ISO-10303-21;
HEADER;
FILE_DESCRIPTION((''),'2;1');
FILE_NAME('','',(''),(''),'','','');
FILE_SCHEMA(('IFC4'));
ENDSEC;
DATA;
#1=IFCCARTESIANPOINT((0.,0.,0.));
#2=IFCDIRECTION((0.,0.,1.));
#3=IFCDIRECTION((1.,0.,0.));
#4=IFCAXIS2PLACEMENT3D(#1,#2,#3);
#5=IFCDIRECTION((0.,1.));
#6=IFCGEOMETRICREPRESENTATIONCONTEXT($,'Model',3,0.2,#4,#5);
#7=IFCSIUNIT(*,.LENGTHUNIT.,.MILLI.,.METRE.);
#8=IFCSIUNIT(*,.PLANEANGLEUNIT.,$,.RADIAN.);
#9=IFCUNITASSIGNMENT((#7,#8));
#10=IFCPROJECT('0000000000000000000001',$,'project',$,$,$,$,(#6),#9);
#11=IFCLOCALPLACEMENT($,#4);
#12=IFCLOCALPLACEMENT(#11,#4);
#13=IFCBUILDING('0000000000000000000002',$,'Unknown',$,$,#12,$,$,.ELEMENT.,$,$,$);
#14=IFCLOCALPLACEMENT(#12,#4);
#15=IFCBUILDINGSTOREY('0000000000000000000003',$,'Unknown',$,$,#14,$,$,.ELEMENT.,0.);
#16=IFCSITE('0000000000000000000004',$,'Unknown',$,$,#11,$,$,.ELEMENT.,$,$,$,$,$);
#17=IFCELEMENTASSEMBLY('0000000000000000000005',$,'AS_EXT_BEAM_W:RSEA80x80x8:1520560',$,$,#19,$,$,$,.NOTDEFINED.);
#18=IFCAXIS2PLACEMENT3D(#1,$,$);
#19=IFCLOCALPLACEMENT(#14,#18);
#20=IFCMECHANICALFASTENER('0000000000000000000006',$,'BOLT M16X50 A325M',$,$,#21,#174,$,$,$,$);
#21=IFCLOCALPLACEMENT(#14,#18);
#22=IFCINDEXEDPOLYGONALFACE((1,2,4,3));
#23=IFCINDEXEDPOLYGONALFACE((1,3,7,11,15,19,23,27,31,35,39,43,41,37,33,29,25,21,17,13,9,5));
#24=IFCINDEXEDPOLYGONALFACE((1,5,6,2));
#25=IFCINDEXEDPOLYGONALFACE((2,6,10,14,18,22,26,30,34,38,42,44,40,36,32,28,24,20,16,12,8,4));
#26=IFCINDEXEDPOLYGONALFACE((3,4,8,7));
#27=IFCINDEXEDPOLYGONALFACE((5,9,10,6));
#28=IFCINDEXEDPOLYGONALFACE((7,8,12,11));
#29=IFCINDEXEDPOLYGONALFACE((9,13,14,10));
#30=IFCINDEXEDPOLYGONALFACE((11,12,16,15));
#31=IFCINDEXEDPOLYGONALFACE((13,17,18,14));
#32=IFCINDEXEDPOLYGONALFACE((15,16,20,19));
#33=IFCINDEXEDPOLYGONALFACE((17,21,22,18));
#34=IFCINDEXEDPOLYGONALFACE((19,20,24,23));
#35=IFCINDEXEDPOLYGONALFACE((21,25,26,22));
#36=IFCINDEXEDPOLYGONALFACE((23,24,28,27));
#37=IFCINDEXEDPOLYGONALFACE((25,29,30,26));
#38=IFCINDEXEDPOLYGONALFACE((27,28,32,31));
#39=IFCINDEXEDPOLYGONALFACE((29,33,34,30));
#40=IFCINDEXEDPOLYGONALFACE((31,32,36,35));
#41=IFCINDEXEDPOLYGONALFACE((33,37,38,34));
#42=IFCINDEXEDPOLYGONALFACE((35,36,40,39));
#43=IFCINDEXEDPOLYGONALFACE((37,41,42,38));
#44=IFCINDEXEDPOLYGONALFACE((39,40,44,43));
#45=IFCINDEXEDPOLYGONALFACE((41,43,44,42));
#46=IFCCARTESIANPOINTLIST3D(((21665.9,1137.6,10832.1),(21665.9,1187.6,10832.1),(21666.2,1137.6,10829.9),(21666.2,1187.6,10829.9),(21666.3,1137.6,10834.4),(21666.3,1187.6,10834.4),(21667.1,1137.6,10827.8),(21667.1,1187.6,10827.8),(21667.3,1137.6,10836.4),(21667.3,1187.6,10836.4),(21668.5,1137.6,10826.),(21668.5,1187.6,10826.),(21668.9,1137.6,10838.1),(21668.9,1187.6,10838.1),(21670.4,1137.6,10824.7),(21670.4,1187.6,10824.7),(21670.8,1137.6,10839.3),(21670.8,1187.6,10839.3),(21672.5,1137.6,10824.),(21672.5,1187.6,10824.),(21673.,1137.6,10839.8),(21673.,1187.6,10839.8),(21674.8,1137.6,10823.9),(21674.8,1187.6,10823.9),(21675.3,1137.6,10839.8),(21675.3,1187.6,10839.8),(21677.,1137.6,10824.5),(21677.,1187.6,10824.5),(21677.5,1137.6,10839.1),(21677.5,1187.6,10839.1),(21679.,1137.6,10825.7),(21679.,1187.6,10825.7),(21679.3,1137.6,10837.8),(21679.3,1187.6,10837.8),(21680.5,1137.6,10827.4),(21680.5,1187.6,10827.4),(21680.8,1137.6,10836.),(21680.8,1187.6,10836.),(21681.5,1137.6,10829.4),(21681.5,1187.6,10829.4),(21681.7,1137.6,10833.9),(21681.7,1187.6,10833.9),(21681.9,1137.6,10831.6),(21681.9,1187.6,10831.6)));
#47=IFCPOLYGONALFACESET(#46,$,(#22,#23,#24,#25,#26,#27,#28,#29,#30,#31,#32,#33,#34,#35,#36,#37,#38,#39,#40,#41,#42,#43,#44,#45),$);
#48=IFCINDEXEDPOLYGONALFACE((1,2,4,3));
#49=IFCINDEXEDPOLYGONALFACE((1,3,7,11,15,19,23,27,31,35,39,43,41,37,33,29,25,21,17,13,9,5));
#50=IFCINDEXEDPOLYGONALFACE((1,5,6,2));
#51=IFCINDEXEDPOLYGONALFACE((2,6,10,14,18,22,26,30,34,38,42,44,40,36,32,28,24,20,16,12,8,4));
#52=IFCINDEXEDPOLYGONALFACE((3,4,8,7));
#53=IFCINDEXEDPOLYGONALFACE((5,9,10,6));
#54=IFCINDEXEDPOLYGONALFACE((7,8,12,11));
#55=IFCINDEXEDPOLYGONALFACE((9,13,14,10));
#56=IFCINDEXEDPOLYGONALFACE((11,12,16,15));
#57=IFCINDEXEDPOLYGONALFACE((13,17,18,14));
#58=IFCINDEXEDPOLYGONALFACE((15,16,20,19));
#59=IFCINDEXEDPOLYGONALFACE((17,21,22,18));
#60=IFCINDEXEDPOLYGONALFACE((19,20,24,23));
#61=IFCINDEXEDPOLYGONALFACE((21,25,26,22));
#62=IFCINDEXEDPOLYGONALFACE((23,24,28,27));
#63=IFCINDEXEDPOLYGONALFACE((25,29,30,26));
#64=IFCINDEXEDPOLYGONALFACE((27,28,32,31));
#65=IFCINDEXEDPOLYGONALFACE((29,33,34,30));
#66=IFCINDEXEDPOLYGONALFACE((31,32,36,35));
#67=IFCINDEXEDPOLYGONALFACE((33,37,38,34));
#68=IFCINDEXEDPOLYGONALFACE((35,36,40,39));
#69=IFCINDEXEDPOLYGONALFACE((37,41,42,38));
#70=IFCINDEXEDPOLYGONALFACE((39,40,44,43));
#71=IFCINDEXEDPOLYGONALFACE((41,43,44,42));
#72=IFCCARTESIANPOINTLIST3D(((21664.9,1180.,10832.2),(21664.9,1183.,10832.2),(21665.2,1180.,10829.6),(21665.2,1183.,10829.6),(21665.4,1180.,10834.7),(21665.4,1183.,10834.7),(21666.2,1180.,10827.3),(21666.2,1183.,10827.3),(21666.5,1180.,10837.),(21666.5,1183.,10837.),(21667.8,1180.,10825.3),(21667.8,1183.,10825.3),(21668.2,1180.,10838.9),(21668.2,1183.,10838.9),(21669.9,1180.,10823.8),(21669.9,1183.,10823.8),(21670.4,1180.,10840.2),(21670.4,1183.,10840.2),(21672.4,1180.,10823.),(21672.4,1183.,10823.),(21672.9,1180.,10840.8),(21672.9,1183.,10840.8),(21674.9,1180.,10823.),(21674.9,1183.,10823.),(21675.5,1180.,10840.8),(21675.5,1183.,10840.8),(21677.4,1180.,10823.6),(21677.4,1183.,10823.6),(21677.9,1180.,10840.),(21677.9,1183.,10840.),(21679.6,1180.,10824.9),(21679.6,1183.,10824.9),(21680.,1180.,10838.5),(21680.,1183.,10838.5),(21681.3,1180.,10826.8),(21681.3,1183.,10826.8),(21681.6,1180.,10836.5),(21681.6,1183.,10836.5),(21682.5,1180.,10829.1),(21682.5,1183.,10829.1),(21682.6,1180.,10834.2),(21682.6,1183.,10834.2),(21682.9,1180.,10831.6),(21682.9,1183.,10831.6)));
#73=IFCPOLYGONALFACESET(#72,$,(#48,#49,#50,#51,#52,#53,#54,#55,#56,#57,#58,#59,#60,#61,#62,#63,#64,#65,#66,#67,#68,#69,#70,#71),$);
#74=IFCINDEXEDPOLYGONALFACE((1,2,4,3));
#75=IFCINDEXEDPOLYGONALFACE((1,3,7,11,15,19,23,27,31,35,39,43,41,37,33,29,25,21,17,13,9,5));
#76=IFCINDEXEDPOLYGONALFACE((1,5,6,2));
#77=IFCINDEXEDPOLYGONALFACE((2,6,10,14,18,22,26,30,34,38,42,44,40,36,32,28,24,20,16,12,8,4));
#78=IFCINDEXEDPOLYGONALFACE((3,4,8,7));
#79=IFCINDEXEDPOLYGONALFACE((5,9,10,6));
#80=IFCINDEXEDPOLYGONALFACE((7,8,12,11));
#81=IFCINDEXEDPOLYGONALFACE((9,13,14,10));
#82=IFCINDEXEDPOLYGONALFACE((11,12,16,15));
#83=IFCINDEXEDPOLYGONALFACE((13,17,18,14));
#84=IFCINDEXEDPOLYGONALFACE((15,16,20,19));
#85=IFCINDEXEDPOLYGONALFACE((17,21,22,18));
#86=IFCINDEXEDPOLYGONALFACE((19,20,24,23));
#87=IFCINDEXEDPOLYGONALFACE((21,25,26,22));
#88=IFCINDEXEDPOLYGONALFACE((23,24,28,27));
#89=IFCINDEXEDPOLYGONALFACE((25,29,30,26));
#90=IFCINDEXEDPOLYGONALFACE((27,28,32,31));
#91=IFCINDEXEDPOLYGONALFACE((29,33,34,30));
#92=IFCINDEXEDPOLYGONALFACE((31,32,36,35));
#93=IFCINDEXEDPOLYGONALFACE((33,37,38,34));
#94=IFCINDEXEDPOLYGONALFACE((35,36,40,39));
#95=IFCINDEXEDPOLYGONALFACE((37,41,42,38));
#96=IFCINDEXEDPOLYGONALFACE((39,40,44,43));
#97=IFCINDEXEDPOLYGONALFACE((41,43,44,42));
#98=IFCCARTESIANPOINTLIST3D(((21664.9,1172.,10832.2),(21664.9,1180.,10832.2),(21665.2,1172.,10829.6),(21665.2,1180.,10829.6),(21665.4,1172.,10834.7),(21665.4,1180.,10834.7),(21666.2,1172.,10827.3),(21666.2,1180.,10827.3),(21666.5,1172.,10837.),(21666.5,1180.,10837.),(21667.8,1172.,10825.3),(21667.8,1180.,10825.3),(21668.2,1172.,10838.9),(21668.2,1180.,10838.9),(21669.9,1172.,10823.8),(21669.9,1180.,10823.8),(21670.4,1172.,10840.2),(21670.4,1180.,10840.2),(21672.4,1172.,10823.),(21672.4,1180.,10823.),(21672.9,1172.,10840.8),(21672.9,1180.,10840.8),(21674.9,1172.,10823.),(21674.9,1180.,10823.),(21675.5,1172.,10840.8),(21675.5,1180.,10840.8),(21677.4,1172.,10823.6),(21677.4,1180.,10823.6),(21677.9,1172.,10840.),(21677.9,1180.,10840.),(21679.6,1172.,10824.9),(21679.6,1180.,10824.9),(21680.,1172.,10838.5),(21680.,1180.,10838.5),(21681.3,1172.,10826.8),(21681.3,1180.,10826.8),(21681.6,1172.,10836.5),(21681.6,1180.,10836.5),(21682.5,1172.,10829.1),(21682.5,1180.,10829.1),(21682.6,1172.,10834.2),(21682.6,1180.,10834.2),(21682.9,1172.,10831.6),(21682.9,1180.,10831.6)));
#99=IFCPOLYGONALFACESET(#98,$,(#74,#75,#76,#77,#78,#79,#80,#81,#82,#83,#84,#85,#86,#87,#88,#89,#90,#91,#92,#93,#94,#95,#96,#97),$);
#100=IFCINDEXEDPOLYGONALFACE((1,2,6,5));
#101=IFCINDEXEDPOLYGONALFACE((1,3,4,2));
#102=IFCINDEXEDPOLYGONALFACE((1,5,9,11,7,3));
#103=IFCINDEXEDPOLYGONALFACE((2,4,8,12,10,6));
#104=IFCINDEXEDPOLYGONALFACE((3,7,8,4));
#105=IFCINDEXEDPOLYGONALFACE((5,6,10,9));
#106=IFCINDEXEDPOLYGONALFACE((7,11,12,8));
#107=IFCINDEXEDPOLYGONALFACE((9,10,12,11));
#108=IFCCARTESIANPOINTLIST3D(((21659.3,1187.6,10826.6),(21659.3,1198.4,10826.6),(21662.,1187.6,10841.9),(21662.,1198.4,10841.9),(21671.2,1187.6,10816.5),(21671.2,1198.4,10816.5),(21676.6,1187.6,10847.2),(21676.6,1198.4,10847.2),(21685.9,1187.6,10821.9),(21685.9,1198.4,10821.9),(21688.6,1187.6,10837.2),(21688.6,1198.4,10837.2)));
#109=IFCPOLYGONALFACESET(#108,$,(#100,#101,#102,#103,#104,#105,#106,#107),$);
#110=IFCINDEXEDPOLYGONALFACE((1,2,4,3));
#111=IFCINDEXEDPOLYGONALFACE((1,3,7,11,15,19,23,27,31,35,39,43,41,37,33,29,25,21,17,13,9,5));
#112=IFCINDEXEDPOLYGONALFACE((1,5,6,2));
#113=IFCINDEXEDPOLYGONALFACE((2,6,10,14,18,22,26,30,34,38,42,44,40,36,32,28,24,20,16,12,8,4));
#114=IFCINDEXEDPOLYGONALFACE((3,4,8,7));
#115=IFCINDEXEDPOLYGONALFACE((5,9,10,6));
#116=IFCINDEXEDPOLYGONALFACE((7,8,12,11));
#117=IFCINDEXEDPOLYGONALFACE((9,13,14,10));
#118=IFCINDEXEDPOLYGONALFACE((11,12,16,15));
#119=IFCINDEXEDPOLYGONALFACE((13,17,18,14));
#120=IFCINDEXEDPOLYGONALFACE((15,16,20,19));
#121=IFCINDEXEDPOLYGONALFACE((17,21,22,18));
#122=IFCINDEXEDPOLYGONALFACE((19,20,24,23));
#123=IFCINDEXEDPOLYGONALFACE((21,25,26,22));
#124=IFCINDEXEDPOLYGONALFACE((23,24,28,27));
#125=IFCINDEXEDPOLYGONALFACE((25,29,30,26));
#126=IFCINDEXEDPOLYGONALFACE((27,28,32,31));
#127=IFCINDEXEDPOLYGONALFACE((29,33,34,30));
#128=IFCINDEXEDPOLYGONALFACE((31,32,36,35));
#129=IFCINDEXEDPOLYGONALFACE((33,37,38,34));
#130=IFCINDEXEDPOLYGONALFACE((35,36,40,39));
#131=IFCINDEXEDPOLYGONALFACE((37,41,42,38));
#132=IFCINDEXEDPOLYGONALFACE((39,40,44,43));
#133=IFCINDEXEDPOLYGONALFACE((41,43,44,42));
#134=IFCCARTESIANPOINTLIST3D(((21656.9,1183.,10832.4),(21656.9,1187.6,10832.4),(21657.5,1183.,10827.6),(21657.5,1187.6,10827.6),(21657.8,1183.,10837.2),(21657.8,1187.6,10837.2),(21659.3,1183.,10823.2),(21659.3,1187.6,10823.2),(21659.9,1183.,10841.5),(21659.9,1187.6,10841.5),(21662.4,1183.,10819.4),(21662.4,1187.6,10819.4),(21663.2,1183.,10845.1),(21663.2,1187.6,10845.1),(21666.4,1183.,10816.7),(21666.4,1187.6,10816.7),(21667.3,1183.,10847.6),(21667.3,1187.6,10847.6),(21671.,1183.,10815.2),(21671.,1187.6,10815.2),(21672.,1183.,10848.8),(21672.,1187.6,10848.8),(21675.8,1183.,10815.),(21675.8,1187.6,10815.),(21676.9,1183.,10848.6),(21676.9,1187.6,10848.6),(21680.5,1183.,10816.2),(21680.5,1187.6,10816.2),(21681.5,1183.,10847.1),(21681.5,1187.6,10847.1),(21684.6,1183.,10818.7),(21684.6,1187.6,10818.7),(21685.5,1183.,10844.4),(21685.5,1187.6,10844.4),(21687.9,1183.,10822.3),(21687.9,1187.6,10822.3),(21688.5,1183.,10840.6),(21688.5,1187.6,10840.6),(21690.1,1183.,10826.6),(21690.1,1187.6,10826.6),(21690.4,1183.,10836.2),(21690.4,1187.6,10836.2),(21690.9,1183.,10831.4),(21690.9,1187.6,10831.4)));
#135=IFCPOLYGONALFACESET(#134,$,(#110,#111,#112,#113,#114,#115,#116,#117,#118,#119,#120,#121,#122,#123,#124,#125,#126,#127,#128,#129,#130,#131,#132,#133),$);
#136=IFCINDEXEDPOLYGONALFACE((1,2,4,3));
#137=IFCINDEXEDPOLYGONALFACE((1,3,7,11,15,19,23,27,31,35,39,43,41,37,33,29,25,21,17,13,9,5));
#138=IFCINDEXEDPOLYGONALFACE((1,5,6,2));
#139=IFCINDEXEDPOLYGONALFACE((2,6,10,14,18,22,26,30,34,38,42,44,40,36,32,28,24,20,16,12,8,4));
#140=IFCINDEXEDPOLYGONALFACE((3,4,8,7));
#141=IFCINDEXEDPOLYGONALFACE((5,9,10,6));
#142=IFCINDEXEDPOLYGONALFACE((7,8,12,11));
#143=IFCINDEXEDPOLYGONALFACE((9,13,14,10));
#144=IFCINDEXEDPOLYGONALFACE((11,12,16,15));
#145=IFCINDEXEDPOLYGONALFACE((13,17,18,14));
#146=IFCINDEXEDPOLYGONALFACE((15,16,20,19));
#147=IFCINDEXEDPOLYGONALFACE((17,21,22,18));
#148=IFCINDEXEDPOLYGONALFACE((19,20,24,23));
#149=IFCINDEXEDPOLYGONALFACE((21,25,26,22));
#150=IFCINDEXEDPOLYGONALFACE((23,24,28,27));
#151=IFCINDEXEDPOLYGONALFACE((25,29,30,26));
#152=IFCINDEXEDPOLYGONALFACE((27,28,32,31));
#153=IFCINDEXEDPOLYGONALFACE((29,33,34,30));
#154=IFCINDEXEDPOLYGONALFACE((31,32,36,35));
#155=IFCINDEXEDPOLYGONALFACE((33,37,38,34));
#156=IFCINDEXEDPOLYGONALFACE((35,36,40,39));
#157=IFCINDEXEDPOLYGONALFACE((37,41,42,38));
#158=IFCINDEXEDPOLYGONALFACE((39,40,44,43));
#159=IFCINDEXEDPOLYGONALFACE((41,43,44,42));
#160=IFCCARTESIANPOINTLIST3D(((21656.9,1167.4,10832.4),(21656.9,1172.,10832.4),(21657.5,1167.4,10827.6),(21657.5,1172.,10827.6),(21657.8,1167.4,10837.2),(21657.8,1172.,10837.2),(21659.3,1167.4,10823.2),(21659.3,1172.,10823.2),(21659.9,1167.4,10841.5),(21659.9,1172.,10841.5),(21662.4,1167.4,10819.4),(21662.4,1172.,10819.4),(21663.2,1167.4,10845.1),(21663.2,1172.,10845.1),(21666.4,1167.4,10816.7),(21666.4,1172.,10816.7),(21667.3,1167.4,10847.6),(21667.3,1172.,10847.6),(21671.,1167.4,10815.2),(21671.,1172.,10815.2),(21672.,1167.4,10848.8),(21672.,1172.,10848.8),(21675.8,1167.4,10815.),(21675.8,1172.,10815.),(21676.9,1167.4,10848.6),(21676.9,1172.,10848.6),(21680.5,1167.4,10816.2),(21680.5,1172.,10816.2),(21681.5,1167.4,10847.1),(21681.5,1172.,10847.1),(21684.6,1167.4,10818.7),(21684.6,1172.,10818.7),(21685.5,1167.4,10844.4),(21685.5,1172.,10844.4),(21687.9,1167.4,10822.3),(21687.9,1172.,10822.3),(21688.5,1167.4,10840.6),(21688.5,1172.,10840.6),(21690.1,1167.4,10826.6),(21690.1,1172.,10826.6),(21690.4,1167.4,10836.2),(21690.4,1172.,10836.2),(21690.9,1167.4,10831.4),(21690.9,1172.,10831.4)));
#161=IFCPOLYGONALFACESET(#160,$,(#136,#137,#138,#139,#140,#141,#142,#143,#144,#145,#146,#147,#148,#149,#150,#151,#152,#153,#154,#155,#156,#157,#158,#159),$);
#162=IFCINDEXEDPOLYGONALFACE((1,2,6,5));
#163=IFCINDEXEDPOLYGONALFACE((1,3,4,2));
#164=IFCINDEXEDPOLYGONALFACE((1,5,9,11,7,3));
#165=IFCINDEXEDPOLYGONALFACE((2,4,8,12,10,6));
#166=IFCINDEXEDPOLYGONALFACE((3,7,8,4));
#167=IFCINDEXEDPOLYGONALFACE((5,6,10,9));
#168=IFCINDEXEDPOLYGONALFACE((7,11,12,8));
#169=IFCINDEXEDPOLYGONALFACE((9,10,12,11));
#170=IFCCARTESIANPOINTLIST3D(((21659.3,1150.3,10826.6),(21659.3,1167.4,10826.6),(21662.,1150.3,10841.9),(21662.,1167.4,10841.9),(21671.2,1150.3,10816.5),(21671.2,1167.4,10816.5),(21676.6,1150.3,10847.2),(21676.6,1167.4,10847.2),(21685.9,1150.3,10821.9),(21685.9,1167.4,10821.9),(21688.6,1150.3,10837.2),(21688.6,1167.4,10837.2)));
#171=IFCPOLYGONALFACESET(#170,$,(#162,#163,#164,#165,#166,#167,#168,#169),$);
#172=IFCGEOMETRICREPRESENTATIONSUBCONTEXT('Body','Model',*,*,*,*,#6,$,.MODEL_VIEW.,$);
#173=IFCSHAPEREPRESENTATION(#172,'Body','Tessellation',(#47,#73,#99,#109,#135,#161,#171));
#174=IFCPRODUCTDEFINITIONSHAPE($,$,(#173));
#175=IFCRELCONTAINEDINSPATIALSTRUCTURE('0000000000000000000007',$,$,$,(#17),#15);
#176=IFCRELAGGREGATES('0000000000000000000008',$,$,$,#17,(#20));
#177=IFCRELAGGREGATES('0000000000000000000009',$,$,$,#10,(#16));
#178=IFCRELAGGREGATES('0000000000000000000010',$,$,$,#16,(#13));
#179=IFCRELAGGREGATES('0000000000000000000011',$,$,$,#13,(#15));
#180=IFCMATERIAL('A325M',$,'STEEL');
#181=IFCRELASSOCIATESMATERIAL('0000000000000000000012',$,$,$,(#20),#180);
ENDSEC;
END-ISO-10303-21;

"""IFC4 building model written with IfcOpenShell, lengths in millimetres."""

from ifc_helpers import new_model, si_unit, direction, frame, origin_with_axes, place, context, subcontext, project, spatial, line, arc, indexed_curve, outline, extrude, source, transform, mapped, material, element, aggregate, save


model = new_model("IFC4")

# Units and contexts
model_context = context("Model", 3, precision=0.2, world=origin_with_axes(), true_north=direction((0.0, 1.0)))
body_context = subcontext(model_context, "Body", "Model", "MODEL_VIEW")
ifc_project = project(units=[si_unit("LENGTHUNIT", "METRE", prefix="MILLI"), si_unit("PLANEANGLEUNIT", "RADIAN")], contexts=[model_context])

# Site, building, storey
site_placement = place(None, origin_with_axes())
site = spatial("IfcSite", under=ifc_project, at=site_placement, Name="Unknown", CompositionType="ELEMENT")
building_placement = place(site_placement, origin_with_axes())
building = spatial("IfcBuilding", under=site, at=building_placement, Name="Unknown", CompositionType="ELEMENT")
storey_placement = place(building_placement, origin_with_axes())
storey = spatial("IfcBuildingStorey", under=building, at=storey_placement, Name="Unknown", CompositionType="ELEMENT", Elevation=0.0)

# Shared definitions
ifc_material_1 = material(Name="A325M", Category="STEEL")
shared_shape = source(origin_with_axes(), body_context, "Body", "SweptSolid", [
    extrude(outline(indexed_curve([(8.0, 0.0), (0.0, 8.0), (-8.0, 0.0), (0.0, -8.0)], segments=[arc(1, 2, 3), arc(3, 4, 1)])), frame((0.0, 0.0, 15.6), z_axis=(0.0, 0.0, -1.0), x_axis=(0.0, 1.0, 0.0)), (0.0, 0.0, 1.0), 50.0),
    extrude(outline(indexed_curve([(9.0, 0.0), (0.0, 9.0), (-9.0, 0.0), (0.0, -9.0)], segments=[arc(1, 2, 3), arc(3, 4, 1)])), frame((0.0, 0.0, 11.0), z_axis=(0.0, 0.0, -1.0), x_axis=(0.0, 1.0, 0.0)), (0.0, 0.0, 1.0), 3.0),
    extrude(outline(indexed_curve([(9.0, 0.0), (0.0, 9.0), (-9.0, 0.0), (0.0, -9.0)], segments=[arc(1, 2, 3), arc(3, 4, 1)])), frame((0.0, 0.0, 8.0), z_axis=(0.0, 0.0, -1.0), x_axis=(0.0, 1.0, 0.0)), (0.0, 0.0, 1.0), 8.0),
    extrude(outline(indexed_curve([(15.6, 0.0), (7.8, 13.5), (-7.8, 13.5), (-15.6, 0.0), (-7.8, -13.5), (7.8, -13.5)], segments=[line(1, 2, 3, 4, 5, 6, 1)])), frame((0.0, 0.0, 26.4), z_axis=(0.0, 0.0, -1.0), x_axis=(0.0, 1.0, 0.0)), (0.0, 0.0, 1.0), 10.8),
    extrude(outline(indexed_curve([(17.0, 0.0), (0.0, 17.0), (-17.0, 0.0), (0.0, -17.0)], segments=[arc(1, 2, 3), arc(3, 4, 1)])), frame((0.0, 0.0, 15.6), z_axis=(0.0, 0.0, -1.0), x_axis=(0.0, 1.0, 0.0)), (0.0, 0.0, 1.0), 4.6),
    extrude(outline(indexed_curve([(17.0, 0.0), (0.0, 17.0), (-17.0, 0.0), (0.0, -17.0)], segments=[arc(1, 2, 3), arc(3, 4, 1)])), frame((0.0, 0.0, 0.0), z_axis=(0.0, 0.0, -1.0), x_axis=(0.0, 1.0, 0.0)), (0.0, 0.0, 1.0), 4.6),
    extrude(outline(indexed_curve([(15.6, 0.0), (7.8, 13.5), (-7.8, 13.5), (-15.6, 0.0), (-7.8, -13.5), (7.8, -13.5)], segments=[line(1, 2, 3, 4, 5, 6, 1)])), frame((0.0, 0.0, -4.6), z_axis=(0.0, 0.0, -1.0), x_axis=(0.0, 1.0, 0.0)), (0.0, 0.0, 1.0), 17.1),
])

# Element assembly, mechanical fastener
assembly_1_placement = place(storey_placement, frame((21611.5, 1140.0, 10837.8), z_axis=(0.0, -1.0, 0.0), x_axis=(0.984808, 0.0, -0.173648)))
assembly_1 = element("IfcElementAssembly", 1, at=assembly_1_placement, inside=storey, Name="AS_EXT_BEAM_W:RSEA80x80x8:1520560", PredefinedType="NOTDEFINED")
mechanical_fastener_1_placement = place(assembly_1_placement, frame((62.5, 5.0, -32.0), z_axis=(0.0, 0.0, -1.0), x_axis=(1.0, 0.0, 0.0)))
mechanical_fastener_1 = element("IfcMechanicalFastener", 2, at=mechanical_fastener_1_placement, material=ifc_material_1, Name="BOLT M16X50 A325M", context=body_context, shape_type="MappedRepresentation", body=[
    mapped(shared_shape, transform((0.0, 0.0, 0.0))),
])
aggregate(assembly_1, [mechanical_fastener_1])

save(model, "model.ifc")
